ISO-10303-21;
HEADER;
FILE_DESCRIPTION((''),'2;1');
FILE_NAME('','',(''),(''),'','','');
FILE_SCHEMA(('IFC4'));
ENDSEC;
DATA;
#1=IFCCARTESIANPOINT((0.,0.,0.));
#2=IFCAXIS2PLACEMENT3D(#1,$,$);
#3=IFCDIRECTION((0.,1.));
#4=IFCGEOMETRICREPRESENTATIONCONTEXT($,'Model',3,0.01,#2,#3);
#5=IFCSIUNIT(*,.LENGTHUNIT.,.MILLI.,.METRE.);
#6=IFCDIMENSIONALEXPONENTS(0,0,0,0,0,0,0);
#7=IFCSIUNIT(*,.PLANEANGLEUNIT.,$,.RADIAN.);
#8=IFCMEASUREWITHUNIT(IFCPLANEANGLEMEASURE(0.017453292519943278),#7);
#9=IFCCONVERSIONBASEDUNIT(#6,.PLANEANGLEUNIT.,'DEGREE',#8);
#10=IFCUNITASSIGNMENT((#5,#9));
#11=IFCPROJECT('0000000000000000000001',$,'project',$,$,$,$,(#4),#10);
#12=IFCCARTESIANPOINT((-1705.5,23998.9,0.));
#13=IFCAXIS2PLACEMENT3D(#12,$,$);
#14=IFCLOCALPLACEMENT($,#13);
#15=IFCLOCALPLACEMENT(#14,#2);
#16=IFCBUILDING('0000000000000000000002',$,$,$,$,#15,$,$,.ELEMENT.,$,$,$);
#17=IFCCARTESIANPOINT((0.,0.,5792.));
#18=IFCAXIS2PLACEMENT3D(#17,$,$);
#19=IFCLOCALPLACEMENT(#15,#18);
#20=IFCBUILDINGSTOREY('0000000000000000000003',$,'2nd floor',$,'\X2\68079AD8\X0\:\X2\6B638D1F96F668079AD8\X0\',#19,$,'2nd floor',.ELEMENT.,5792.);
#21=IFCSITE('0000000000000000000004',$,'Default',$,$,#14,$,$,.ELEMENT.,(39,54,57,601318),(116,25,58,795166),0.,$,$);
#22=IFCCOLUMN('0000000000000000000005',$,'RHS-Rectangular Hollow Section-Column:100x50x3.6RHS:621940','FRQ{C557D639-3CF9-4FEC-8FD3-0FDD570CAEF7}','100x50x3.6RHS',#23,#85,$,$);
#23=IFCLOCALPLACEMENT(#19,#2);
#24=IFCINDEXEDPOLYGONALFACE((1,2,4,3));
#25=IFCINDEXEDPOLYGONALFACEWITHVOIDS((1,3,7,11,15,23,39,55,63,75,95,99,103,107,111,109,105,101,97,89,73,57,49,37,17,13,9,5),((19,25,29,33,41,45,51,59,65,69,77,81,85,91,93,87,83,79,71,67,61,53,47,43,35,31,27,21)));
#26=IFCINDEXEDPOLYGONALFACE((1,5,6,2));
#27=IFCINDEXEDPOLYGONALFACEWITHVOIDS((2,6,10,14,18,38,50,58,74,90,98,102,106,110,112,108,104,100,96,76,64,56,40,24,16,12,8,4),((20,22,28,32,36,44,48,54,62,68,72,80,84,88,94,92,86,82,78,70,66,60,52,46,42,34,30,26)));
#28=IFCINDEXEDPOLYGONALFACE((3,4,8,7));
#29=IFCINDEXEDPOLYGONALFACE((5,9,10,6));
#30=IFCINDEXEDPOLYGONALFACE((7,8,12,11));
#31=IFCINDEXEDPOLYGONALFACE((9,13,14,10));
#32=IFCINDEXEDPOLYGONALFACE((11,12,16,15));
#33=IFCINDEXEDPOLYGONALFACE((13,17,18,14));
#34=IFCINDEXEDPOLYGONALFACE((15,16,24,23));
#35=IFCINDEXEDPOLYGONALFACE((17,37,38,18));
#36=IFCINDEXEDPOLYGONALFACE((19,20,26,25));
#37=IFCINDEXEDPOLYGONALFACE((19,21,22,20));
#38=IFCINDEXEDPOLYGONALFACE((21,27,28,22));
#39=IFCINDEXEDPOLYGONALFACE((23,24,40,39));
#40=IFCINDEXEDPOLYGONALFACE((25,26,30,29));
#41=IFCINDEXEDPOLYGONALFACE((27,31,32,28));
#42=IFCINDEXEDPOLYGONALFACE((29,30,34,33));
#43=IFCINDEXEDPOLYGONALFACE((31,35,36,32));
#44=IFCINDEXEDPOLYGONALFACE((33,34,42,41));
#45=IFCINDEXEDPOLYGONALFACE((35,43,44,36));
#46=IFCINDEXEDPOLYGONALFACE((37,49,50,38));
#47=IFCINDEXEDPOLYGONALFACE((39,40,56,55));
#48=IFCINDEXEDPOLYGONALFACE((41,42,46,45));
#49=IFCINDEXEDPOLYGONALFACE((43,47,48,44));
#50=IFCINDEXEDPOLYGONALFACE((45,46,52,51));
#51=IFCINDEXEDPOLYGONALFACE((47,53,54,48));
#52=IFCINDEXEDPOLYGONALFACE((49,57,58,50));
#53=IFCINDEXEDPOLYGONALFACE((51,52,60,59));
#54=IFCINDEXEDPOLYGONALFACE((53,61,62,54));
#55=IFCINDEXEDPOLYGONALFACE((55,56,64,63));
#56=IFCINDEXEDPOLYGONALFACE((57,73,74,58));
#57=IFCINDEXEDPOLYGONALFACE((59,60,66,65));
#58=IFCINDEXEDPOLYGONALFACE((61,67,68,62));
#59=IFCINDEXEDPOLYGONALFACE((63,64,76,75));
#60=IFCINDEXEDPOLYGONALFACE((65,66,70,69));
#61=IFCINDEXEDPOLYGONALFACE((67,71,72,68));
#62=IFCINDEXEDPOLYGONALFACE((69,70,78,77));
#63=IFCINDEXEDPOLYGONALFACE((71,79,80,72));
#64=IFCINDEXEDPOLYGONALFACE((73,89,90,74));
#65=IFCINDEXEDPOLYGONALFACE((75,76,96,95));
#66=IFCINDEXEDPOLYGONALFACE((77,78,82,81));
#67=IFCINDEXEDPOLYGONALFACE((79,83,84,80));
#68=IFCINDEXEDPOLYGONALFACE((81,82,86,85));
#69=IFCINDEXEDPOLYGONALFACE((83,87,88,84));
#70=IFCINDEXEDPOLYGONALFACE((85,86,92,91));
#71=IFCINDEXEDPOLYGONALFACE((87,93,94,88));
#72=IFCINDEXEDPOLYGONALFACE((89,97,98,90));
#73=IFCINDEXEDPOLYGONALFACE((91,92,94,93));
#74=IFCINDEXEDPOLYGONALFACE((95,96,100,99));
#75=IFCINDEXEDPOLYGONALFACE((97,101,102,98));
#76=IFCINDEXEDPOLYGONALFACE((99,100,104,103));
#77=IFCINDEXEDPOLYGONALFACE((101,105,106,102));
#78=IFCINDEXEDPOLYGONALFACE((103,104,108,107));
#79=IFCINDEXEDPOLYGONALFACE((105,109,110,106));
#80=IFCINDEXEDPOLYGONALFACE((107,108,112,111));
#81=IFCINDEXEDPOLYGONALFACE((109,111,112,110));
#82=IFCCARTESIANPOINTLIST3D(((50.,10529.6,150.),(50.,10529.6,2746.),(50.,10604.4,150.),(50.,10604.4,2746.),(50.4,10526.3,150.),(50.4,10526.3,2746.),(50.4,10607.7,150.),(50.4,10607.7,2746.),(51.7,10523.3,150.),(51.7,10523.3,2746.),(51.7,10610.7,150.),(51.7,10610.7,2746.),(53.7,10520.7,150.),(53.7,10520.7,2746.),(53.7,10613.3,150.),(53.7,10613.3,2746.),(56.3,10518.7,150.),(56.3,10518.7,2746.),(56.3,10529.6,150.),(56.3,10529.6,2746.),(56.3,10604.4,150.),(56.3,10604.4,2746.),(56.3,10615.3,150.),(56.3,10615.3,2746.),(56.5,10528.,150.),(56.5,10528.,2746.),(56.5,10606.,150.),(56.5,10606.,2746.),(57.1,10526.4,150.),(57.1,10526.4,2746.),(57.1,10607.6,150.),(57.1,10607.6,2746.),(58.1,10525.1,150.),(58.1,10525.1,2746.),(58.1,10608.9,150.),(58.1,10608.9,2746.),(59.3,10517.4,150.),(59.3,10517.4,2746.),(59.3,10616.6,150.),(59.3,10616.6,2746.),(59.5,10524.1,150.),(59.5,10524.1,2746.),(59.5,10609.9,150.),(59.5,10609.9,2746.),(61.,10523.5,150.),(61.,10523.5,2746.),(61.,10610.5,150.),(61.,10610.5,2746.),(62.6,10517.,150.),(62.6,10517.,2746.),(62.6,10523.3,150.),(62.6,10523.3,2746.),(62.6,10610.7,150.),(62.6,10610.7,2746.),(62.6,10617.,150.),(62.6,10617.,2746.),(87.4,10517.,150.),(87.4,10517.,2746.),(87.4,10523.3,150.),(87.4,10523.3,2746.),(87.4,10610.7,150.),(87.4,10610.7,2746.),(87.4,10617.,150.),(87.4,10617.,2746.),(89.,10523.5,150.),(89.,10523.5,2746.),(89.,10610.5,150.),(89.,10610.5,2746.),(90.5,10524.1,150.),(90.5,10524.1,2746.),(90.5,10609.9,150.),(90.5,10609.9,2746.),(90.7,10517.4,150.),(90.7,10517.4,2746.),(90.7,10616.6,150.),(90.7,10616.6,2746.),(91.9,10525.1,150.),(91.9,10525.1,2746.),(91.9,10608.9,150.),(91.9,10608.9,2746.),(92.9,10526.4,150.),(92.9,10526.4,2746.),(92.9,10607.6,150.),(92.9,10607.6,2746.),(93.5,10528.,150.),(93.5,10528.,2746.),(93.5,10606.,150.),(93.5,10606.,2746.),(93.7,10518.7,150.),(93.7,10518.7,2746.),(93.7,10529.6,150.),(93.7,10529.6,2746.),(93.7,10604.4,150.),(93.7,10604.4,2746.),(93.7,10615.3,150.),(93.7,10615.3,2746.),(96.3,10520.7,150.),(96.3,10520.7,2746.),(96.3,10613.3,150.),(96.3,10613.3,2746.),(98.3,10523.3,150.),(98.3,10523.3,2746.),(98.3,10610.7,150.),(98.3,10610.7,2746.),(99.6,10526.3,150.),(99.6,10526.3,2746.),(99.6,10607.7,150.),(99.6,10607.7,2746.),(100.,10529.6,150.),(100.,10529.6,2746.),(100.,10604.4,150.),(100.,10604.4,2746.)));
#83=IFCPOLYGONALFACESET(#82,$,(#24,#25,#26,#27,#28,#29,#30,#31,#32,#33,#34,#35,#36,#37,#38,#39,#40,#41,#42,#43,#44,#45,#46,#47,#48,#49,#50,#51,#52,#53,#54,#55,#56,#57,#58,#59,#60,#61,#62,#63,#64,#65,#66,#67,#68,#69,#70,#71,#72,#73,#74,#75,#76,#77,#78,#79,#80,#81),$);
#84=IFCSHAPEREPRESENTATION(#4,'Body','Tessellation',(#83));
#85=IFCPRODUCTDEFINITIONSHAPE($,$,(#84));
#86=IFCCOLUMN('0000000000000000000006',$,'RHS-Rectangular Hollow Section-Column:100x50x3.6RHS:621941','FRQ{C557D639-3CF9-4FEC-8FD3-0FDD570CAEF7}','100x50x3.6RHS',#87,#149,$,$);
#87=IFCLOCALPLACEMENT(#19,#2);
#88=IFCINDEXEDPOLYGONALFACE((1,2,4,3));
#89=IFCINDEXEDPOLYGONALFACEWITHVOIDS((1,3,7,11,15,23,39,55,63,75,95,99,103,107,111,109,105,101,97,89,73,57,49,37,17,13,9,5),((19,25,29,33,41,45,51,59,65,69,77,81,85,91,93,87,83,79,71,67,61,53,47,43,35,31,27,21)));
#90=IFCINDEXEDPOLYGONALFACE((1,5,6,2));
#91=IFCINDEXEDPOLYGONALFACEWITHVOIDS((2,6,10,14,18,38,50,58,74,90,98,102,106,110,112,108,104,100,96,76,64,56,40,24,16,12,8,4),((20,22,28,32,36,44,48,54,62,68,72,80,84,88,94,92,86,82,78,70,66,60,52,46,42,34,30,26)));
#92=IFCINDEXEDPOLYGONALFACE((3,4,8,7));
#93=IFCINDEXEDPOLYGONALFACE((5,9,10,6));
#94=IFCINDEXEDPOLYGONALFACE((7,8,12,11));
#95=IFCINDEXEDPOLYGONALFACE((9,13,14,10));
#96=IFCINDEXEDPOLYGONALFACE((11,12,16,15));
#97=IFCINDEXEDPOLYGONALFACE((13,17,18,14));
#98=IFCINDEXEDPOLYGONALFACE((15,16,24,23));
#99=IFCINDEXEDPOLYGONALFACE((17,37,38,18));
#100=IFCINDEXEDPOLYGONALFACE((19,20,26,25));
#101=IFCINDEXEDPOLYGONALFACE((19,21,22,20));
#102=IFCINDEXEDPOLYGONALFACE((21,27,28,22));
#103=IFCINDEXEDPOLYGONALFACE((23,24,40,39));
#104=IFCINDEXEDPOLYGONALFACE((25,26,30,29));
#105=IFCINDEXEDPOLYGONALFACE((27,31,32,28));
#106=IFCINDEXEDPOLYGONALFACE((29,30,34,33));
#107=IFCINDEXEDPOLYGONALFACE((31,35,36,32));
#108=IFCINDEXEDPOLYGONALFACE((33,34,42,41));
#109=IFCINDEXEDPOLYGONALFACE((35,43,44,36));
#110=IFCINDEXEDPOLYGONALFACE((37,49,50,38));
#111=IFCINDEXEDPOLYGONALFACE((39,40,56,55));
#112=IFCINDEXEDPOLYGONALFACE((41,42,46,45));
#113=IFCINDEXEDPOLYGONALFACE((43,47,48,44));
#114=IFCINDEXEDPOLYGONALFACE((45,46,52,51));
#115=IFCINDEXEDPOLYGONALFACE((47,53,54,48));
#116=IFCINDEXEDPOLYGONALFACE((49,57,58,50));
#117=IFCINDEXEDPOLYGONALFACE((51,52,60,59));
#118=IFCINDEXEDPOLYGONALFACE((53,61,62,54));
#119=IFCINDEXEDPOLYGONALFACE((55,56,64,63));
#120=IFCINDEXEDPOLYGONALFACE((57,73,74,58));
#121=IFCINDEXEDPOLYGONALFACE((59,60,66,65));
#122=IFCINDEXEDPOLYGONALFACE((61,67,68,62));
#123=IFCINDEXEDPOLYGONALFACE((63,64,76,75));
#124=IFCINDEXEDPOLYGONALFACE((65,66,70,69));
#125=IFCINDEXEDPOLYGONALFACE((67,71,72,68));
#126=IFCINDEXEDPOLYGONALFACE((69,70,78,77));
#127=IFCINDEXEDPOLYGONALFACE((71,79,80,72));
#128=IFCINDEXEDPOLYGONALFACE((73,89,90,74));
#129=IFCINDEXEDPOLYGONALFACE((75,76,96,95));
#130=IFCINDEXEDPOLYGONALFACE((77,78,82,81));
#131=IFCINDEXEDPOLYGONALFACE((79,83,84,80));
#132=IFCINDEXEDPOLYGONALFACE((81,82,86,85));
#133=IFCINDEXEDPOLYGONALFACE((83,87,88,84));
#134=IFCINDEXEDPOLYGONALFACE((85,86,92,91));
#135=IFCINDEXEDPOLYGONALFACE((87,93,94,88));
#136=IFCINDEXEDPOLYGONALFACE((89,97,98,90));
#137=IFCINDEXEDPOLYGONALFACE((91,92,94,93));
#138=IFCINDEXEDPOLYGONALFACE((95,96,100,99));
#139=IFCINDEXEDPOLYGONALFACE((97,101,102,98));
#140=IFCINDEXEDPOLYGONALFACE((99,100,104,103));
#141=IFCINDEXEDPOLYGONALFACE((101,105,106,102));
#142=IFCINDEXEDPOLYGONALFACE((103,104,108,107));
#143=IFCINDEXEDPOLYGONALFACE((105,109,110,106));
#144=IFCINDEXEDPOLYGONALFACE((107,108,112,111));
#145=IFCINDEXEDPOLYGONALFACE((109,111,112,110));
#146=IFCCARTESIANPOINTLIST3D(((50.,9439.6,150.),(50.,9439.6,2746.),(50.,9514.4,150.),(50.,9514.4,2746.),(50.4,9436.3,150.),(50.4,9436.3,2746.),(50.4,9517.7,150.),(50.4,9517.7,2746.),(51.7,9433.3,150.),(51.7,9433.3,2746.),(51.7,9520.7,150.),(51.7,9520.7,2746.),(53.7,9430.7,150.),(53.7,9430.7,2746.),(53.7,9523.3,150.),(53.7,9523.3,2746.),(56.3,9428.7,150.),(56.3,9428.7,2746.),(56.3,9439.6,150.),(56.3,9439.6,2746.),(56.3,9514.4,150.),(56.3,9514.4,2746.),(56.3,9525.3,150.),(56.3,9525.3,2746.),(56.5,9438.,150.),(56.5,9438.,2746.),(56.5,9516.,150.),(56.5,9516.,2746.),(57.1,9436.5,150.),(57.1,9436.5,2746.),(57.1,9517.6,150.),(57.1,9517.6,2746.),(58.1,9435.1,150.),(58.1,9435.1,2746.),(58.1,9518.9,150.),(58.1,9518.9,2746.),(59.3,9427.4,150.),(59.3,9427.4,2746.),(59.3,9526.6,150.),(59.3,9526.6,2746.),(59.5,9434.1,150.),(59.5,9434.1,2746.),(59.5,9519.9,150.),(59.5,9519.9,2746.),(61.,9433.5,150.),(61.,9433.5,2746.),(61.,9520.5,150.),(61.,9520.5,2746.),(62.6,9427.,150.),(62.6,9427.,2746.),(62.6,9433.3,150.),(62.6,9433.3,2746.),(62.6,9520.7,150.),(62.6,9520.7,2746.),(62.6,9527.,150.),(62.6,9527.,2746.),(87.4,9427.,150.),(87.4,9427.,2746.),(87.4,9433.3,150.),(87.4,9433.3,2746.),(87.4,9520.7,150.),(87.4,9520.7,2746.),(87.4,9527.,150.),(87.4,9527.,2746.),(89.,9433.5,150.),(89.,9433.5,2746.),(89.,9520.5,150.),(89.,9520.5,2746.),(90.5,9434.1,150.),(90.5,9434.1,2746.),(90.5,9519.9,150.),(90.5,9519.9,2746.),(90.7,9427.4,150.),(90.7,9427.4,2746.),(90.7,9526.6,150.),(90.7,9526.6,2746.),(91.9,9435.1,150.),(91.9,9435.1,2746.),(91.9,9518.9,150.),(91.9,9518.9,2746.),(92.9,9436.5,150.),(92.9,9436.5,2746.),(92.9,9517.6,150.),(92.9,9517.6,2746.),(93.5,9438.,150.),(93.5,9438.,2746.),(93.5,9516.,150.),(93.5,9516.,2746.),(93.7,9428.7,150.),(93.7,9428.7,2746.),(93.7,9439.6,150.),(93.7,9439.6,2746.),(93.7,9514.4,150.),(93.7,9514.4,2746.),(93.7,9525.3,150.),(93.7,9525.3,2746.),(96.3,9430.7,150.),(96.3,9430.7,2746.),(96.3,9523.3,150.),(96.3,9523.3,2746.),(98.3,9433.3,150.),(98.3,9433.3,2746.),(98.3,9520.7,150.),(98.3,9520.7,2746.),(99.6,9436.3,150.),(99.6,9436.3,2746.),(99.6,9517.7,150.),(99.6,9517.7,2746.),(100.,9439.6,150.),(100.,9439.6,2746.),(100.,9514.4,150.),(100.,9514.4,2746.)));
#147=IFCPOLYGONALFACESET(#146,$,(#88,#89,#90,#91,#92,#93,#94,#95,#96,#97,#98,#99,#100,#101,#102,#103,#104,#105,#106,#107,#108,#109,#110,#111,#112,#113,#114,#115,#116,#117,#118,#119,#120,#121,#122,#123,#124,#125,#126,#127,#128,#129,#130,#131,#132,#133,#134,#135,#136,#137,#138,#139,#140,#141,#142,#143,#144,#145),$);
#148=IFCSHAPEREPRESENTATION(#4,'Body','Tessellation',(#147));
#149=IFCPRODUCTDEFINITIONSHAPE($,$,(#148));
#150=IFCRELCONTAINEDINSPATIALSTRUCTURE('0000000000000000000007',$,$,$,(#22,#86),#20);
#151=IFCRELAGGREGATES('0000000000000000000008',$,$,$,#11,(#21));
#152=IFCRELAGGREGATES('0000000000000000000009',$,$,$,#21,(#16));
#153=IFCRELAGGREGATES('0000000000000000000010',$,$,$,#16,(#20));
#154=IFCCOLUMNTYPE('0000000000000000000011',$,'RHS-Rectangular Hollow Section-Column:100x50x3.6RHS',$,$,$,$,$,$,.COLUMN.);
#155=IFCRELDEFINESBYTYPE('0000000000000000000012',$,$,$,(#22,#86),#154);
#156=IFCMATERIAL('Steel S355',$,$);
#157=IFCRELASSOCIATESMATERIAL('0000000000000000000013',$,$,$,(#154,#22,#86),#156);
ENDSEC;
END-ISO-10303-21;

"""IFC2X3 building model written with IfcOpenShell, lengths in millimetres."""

from ifc_helpers import new_model, entity, si_unit, converted_unit, direction, frame, origin, origin_2d, place, context, project, spatial, hollow_rectangle, extrude, clip, halfspace, material, type_object, element, save


model = new_model("IFC2X3")

# Units and contexts
model_context = context("Model", 3, precision=0.01, world=origin(), true_north=direction((0.0, 1.0)))
ifc_project = project(units=[si_unit("LENGTHUNIT", "METRE", prefix="MILLI"), converted_unit("PLANEANGLEUNIT", "DEGREE", entity("IfcPlaneAngleMeasure", 0.017453292519943278), si_unit("PLANEANGLEUNIT", "RADIAN"), dimensions=[0, 0, 0, 0, 0, 0, 0])], contexts=[model_context])

# Site, building, storey
site_placement = place(None, frame((-1705.5, 23998.9, 0.0)))
site = spatial("IfcSite", under=ifc_project, at=site_placement, Name="Default", CompositionType="ELEMENT", RefLatitude=(39, 54, 57, 601318), RefLongitude=(116, 25, 58, 795166), RefElevation=0.0)
building_placement = place(site_placement, origin())
building = spatial("IfcBuilding", under=site, at=building_placement, CompositionType="ELEMENT")
storey_placement = place(building_placement, frame((0.0, 0.0, 5792.0)))
storey = spatial("IfcBuildingStorey", under=building, at=storey_placement, Name="2nd floor", ObjectType="标高:正负零标高", LongName="2nd floor", CompositionType="ELEMENT", Elevation=5792.0)

# Shared definitions
ifc_material_1 = material(Name="Steel S355")

# Columns
column_type_1 = type_object("IfcColumnType", Name="RHS-Rectangular Hollow Section-Column:100x50x3.6RHS", PredefinedType="COLUMN", material=ifc_material_1)
column_1_placement = place(storey_placement, frame((75.0, 10567.0, 2746.0), z_axis=(0.0, 0.0, 1.0), x_axis=(-1.0, 0.0, 0.0)))
element("IfcColumn", 1, at=column_1_placement, inside=storey, type_object=column_type_1, material=ifc_material_1, Name="RHS-Rectangular Hollow Section-Column:100x50x3.6RHS:621940", Description="FRQ{C557D639-3CF9-4FEC-8FD3-0FDD570CAEF7}", ObjectType="100x50x3.6RHS", context=model_context, shape_type="Clipping", body=[
    clip(extrude(hollow_rectangle(XDim=50.0, YDim=100.0, WallThickness=6.3, InnerFilletRadius=6.3, OuterFilletRadius=12.6, at=origin_2d()), origin(), (0.0, 0.0, -1.0), 2651.9), halfspace(frame((75.0, 10567.0, -2596.0), z_axis=(0.0, 0.0, 1.0), x_axis=(-1.0, 0.0, 0.0)), True)),
])
column_2_placement = place(storey_placement, frame((75.0, 9477.0, 2746.0), z_axis=(0.0, 0.0, 1.0), x_axis=(-1.0, 0.0, 0.0)))
element("IfcColumn", 2, at=column_2_placement, inside=storey, type_object=column_type_1, material=ifc_material_1, Name="RHS-Rectangular Hollow Section-Column:100x50x3.6RHS:621941", Description="FRQ{C557D639-3CF9-4FEC-8FD3-0FDD570CAEF7}", ObjectType="100x50x3.6RHS", context=model_context, shape_type="Clipping", body=[
    clip(extrude(hollow_rectangle(XDim=50.0, YDim=100.0, WallThickness=6.3, InnerFilletRadius=6.3, OuterFilletRadius=12.6, at=origin_2d()), origin(), (0.0, 0.0, -1.0), 2651.9), halfspace(frame((75.0, 9477.0, -2596.0), z_axis=(0.0, 0.0, 1.0), x_axis=(-1.0, 0.0, 0.0)), True)),
])

save(model, "model.ifc")
